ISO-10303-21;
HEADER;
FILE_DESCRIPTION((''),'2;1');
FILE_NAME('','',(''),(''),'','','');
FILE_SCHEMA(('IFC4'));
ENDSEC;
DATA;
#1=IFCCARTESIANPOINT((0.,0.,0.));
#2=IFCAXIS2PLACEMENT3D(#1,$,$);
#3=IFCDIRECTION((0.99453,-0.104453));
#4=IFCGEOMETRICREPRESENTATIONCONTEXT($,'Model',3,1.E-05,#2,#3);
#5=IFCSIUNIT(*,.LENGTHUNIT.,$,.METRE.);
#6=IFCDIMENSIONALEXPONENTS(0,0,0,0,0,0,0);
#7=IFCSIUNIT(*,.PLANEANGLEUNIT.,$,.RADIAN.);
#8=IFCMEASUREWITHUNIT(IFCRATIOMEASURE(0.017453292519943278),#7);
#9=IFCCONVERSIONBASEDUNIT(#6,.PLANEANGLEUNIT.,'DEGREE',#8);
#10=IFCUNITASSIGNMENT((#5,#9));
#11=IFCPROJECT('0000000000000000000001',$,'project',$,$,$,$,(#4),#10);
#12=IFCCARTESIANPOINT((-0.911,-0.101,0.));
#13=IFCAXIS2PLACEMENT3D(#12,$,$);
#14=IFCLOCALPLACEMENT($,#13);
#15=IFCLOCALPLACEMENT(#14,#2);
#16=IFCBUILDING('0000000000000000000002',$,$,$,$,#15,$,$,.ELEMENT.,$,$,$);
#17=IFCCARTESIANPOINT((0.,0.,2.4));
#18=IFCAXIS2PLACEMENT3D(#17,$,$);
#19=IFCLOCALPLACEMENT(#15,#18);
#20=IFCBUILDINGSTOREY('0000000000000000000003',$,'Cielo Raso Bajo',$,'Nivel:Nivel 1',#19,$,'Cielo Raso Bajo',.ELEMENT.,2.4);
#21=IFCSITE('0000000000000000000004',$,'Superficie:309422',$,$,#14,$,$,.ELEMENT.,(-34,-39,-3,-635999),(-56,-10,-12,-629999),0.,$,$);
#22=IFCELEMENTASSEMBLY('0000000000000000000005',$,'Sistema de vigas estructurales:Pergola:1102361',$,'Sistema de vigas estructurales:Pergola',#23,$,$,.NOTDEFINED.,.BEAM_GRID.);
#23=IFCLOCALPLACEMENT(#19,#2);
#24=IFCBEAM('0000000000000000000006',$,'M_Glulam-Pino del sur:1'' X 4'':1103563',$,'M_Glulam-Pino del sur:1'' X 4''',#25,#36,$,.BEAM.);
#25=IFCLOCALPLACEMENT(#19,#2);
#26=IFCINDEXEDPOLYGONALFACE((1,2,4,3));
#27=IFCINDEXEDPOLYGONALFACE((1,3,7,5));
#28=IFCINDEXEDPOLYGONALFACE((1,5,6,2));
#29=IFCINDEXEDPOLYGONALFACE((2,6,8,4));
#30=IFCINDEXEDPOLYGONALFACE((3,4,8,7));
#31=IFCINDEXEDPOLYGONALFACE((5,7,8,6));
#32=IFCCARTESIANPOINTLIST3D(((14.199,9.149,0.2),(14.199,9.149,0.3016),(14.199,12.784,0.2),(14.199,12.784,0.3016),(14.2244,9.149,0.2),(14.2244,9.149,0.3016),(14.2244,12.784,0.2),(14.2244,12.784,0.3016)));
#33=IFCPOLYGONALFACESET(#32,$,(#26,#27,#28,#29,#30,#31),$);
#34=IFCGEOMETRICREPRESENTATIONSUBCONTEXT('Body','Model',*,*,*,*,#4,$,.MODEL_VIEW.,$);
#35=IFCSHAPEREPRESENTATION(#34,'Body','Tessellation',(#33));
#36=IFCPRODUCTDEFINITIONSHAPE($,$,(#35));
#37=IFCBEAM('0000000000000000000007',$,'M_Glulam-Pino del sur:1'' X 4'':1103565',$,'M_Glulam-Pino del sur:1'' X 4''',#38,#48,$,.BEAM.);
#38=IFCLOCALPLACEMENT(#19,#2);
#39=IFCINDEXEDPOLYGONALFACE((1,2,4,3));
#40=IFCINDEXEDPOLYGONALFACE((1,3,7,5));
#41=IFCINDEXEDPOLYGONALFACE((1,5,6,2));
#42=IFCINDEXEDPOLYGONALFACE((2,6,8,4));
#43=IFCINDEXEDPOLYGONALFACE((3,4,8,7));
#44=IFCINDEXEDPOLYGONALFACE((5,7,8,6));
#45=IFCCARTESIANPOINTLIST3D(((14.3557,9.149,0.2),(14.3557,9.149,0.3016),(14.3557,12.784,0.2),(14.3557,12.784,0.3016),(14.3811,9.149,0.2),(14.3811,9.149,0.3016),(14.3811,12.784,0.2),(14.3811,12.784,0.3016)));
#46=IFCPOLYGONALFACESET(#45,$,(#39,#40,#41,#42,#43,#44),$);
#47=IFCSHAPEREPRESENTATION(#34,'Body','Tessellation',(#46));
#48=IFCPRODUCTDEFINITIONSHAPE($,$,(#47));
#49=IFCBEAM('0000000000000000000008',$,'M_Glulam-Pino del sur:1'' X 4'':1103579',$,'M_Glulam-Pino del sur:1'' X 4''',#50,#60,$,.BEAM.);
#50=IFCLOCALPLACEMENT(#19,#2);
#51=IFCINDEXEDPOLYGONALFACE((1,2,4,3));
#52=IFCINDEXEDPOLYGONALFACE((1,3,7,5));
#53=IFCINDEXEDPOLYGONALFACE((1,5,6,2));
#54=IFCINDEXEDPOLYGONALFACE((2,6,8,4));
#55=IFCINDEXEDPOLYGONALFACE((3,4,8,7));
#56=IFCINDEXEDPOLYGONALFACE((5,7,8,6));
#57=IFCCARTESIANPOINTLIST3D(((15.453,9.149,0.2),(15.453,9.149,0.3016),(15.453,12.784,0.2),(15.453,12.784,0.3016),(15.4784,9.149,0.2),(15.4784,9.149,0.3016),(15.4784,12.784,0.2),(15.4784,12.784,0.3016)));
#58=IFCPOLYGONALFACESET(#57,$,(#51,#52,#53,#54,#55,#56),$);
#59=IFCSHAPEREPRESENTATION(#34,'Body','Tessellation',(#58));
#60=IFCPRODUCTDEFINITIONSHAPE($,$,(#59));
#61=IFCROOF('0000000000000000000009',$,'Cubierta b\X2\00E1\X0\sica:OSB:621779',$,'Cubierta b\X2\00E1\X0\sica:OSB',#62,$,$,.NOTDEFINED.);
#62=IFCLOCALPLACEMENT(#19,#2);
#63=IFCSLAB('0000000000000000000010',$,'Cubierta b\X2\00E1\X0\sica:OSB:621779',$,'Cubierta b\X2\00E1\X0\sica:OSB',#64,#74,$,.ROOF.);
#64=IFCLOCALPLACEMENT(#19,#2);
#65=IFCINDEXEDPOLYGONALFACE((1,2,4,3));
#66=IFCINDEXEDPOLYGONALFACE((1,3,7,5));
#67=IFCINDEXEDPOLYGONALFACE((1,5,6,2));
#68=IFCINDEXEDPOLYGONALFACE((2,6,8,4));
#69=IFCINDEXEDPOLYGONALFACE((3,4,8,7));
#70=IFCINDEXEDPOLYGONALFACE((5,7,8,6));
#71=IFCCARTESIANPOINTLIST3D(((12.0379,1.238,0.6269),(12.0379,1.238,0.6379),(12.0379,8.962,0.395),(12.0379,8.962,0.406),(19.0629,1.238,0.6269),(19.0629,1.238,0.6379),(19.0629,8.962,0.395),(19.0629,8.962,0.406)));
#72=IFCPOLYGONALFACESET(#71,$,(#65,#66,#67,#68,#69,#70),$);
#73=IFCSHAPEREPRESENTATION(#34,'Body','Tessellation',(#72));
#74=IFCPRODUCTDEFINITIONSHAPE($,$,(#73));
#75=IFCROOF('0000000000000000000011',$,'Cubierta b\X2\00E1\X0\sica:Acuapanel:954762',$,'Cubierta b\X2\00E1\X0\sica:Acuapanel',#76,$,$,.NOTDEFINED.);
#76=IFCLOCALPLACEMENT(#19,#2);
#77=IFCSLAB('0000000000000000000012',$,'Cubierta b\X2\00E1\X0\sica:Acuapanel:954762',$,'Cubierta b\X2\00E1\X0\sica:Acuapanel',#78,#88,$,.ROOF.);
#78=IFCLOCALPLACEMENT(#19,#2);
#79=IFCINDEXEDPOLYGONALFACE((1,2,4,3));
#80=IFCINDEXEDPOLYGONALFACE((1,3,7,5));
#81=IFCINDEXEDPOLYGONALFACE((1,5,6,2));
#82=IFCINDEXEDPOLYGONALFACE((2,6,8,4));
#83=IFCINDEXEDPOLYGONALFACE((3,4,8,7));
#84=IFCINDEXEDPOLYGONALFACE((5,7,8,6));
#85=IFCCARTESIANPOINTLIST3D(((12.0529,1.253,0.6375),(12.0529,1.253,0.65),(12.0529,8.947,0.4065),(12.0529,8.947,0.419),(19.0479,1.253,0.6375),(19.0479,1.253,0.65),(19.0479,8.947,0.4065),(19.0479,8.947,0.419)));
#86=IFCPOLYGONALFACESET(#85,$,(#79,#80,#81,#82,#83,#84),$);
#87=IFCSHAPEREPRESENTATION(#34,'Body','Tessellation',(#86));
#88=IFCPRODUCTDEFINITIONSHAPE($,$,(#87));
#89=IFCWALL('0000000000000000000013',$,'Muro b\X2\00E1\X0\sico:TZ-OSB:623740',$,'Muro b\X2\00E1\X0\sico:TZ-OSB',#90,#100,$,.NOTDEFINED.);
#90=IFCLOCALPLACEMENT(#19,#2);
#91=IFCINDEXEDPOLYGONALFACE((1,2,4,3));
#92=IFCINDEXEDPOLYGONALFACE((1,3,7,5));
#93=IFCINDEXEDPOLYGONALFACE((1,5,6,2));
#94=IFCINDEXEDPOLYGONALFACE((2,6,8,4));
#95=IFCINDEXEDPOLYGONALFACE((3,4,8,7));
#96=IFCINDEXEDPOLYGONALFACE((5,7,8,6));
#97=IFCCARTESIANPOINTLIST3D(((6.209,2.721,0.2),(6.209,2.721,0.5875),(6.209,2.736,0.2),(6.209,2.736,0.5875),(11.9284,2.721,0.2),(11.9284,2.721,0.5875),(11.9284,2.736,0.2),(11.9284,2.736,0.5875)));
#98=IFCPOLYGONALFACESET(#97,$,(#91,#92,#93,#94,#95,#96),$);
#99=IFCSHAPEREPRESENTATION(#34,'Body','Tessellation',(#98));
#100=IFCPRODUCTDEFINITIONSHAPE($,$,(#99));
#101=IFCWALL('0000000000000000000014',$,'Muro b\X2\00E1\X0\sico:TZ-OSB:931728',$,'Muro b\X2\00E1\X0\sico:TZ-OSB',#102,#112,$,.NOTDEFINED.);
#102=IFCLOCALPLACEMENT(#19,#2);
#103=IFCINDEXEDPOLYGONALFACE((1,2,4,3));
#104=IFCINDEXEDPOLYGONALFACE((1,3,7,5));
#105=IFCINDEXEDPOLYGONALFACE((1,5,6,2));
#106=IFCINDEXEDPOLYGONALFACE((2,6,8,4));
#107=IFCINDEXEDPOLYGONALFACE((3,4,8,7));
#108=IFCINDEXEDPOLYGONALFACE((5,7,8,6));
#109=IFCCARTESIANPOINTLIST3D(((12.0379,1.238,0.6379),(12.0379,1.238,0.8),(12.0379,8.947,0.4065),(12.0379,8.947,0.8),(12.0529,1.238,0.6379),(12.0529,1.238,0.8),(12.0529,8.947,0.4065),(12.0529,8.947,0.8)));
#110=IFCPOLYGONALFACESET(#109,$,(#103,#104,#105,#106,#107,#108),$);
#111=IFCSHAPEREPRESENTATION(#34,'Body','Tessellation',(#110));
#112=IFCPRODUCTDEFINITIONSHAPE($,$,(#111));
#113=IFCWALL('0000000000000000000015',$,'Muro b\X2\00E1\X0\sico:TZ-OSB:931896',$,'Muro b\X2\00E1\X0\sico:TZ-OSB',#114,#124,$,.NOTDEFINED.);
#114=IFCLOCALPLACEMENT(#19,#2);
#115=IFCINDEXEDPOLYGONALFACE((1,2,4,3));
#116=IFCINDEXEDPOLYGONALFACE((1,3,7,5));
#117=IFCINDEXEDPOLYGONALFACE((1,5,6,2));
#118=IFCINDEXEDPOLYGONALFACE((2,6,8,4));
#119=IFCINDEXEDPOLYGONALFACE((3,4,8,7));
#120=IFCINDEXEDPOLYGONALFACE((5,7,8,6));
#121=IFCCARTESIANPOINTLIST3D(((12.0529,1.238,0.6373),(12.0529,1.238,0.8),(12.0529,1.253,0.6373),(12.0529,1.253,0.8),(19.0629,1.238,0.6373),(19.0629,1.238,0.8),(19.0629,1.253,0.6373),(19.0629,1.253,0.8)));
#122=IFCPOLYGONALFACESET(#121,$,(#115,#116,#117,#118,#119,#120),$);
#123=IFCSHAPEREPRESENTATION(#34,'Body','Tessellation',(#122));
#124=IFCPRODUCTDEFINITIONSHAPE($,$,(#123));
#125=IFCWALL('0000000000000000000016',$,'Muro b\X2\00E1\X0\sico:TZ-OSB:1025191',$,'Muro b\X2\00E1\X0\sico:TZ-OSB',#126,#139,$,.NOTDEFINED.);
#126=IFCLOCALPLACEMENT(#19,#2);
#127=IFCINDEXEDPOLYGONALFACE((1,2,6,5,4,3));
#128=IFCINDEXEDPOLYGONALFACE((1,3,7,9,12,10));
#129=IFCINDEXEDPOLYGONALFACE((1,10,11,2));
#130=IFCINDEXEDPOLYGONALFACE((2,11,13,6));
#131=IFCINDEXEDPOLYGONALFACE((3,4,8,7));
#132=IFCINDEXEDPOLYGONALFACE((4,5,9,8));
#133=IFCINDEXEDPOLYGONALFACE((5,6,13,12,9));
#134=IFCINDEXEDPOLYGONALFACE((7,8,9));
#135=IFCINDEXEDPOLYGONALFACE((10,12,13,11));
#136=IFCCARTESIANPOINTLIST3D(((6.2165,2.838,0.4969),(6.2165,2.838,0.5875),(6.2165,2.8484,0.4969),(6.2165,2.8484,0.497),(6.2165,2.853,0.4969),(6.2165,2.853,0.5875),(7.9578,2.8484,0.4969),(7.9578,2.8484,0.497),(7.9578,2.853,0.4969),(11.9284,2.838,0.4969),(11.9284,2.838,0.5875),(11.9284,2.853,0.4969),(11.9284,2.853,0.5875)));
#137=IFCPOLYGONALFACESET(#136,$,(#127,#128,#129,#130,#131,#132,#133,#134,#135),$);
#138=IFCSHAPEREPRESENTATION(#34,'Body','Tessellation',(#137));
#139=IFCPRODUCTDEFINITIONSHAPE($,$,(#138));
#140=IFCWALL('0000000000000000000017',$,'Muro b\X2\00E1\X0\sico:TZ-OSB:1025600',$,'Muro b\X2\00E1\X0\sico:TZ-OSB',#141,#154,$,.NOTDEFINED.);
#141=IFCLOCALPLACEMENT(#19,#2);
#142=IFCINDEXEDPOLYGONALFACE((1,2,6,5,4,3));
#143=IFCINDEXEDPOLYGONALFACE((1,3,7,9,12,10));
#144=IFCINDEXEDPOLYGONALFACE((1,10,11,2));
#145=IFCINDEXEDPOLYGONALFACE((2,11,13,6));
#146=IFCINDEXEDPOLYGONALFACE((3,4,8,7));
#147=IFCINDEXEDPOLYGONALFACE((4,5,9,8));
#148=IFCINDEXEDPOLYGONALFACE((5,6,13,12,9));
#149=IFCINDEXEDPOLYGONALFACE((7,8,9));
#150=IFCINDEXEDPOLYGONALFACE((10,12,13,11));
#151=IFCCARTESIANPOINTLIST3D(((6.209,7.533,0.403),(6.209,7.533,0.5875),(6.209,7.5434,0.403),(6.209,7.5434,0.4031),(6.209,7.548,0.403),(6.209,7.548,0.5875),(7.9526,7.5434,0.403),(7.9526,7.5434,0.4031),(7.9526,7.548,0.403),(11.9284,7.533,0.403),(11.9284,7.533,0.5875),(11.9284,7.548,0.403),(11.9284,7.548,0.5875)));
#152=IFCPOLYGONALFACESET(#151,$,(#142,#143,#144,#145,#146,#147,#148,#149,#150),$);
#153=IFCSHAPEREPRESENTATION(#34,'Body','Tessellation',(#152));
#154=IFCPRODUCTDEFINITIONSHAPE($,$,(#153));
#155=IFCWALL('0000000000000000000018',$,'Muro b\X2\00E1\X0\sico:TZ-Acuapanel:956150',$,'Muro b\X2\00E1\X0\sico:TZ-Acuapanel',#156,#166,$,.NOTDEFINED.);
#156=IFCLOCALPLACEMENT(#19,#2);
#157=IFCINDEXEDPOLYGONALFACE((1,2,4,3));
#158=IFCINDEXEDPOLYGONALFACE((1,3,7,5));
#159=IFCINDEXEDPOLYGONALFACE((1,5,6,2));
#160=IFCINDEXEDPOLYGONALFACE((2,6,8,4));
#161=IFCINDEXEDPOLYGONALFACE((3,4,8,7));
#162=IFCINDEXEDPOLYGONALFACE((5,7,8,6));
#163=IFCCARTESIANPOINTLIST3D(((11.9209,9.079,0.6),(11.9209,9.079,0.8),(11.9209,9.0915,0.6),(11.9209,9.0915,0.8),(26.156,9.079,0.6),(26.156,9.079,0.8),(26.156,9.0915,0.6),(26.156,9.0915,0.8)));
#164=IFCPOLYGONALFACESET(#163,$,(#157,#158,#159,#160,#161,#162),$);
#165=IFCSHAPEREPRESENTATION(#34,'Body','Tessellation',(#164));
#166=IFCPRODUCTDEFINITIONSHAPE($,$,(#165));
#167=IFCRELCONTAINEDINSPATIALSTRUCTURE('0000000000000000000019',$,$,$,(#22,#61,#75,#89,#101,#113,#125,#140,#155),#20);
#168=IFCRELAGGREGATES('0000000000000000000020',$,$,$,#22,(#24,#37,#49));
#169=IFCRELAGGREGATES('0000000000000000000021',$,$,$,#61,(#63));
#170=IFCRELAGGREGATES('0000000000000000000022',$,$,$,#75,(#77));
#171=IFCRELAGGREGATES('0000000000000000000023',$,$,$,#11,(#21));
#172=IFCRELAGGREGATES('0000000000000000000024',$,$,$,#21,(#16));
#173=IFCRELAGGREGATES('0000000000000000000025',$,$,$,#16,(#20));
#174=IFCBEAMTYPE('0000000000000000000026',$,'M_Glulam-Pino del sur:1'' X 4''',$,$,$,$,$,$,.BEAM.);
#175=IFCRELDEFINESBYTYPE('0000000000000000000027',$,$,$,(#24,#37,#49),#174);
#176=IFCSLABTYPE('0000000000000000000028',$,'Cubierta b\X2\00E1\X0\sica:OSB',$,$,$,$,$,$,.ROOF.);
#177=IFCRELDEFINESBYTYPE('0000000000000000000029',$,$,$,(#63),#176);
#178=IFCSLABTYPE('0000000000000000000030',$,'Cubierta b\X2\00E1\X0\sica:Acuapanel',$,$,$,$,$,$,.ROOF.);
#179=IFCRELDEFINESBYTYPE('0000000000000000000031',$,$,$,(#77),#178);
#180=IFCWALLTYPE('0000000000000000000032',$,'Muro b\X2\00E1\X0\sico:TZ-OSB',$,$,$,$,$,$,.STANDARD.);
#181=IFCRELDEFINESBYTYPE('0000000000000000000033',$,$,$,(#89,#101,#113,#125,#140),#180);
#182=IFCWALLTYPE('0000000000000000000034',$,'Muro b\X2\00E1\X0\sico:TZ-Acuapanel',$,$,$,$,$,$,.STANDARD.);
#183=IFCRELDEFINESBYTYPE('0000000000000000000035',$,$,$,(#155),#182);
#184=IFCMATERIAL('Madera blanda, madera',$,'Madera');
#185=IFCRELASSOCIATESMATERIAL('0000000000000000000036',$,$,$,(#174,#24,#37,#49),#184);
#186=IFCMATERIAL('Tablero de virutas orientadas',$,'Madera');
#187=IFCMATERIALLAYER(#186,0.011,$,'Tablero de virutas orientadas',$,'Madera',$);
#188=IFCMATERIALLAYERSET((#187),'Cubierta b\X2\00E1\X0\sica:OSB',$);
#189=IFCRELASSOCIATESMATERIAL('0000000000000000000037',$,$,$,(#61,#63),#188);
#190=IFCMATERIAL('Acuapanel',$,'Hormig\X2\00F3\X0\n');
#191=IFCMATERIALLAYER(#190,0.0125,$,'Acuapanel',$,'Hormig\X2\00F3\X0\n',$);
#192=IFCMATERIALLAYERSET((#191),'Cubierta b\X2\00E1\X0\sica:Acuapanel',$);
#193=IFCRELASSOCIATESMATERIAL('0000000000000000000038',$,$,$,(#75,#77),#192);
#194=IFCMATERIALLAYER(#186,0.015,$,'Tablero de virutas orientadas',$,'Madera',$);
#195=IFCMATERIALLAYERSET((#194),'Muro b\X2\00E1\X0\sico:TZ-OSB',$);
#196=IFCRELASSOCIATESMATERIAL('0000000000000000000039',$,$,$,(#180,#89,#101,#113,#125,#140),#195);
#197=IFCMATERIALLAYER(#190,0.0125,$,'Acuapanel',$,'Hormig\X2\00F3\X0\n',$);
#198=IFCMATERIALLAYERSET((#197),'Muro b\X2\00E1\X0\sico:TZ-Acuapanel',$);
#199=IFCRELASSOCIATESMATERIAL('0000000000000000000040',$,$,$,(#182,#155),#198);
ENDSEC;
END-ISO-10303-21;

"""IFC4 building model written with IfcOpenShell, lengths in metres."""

from ifc_helpers import new_model, entity, si_unit, converted_unit, direction, frame, frame_2d, origin, origin_2d_with_axis, place, context, subcontext, project, spatial, polyline, segment, composite_curve, rectangle, outline, extrude, clip, halfspace, bounded_halfspace, source, transform, mapped, material, layer, layer_set, layer_usage, material_profile, profile_set, profile_usage, type_object, type_shapes, element, aggregate, save


model = new_model("IFC4")

# Units and contexts
model_context = context("Model", 3, precision=1e-05, world=origin(), true_north=direction((0.99453, -0.104453)))
body_context = subcontext(model_context, "Body", "Model", "MODEL_VIEW")
ifc_project = project(units=[si_unit("LENGTHUNIT", "METRE"), converted_unit("PLANEANGLEUNIT", "DEGREE", entity("IfcRatioMeasure", 0.017453292519943278), si_unit("PLANEANGLEUNIT", "RADIAN"), dimensions=[0, 0, 0, 0, 0, 0, 0])], contexts=[model_context])

# Site, building, storey
site_placement = place(None, frame((-0.911, -0.101, 0.0)))
site = spatial("IfcSite", under=ifc_project, at=site_placement, Name="Superficie:309422", CompositionType="ELEMENT", RefLatitude=(-34, -39, -3, -635999), RefLongitude=(-56, -10, -12, -629999), RefElevation=0.0)
building_placement = place(site_placement, origin())
building = spatial("IfcBuilding", under=site, at=building_placement, CompositionType="ELEMENT")
storey_placement = place(building_placement, frame((0.0, 0.0, 2.4)))
storey = spatial("IfcBuildingStorey", under=building, at=storey_placement, Name="Cielo Raso Bajo", ObjectType="Nivel:Nivel 1", LongName="Cielo Raso Bajo", CompositionType="ELEMENT", Elevation=2.4)

# Element assembly, beams
assembly_placement = place(storey_placement, origin())
assembly = element("IfcElementAssembly", 1, at=assembly_placement, inside=storey, Name="Sistema de vigas estructurales:Pergola:1102361", ObjectType="Sistema de vigas estructurales:Pergola", AssemblyPlace="NOTDEFINED", PredefinedType="BEAM_GRID")
ifc_material_1 = material(Name="Madera blanda, madera", Category="Madera")
ifc_material_profile_1 = material_profile(ifc_material_1, outline(composite_curve([segment(polyline([(-0.0127, 0.0508, 0.0), (0.0127, 0.0508, 0.0)]), True, "CONTINUOUS"), segment(polyline([(0.0127, 0.0508, 0.0), (0.0127, -0.0508, 0.0)]), True, "CONTINUOUS"), segment(polyline([(0.0127, -0.0508, 0.0), (-0.0127, -0.0508, 0.0)]), True, "CONTINUOUS"), segment(polyline([(-0.0127, -0.0508, 0.0), (-0.0127, 0.0508, 0.0)]), True, "CONTINUOUS")], self_intersect=False), kind="CURVE"), Name="1' X 4'")
ifc_material_profile_2 = material_profile(ifc_material_1, outline(composite_curve([segment(polyline([(2.5145, -0.0127, -0.0508), (2.5145, -0.0127, 0.0508)]), True, "CONTINUOUS"), segment(polyline([(2.5145, -0.0127, 0.0508), (-2.5145, -0.0127, 0.0508)]), True, "CONTINUOUS"), segment(polyline([(-2.5145, -0.0127, 0.0508), (-2.5145, -0.0127, -0.0508)]), True, "CONTINUOUS"), segment(polyline([(-2.5145, -0.0127, -0.0508), (2.5145, -0.0127, -0.0508)]), True, "CONTINUOUS")], self_intersect=False), kind="CURVE"), Name="1' X 4'")
ifc_profile_set = profile_set([ifc_material_profile_1, ifc_material_profile_2], Name="1' X 4'")
ifc_profile_usage_1 = profile_usage(ifc_profile_set, cardinal=8)
beam_type = type_object("IfcBeamType", Name="M_Glulam-Pino del sur:1' X 4'", PredefinedType="BEAM", material=ifc_profile_set)
shared_shape = source(origin(), body_context, "Body", "SweptSolid", [
    extrude(rectangle(XDim=0.1016, YDim=0.0254, at=origin_2d_with_axis()), frame((-1.7485, 0.0, 0.0), z_axis=(1.0, 0.0, 0.0), x_axis=(0.0, 0.0, -1.0)), (0.0, 0.0, 1.0), 3.635),
])
type_shapes(beam_type, [shared_shape])
beam_1_placement = place(assembly_placement, frame((14.2117, 10.8975, 0.2508), z_axis=(0.0, 0.0, 1.0), x_axis=(0.0, 1.0, 0.0)))
beam_1 = element("IfcBeam", 2, at=beam_1_placement, type_object=beam_type, material=ifc_profile_usage_1, Name="M_Glulam-Pino del sur:1' X 4':1103563", ObjectType="M_Glulam-Pino del sur:1' X 4'", PredefinedType="BEAM", context=body_context, shape_type="MappedRepresentation", body=[
    mapped(shared_shape, transform((0.0, 0.0, 0.0), scale=1.0)),
])
ifc_profile_usage_2 = profile_usage(ifc_profile_set, cardinal=8)
beam_2_placement = place(assembly_placement, frame((14.3684, 10.8975, 0.2508), z_axis=(0.0, 0.0, 1.0), x_axis=(0.0, 1.0, 0.0)))
beam_2 = element("IfcBeam", 3, at=beam_2_placement, type_object=beam_type, material=ifc_profile_usage_2, Name="M_Glulam-Pino del sur:1' X 4':1103565", ObjectType="M_Glulam-Pino del sur:1' X 4'", PredefinedType="BEAM", context=body_context, shape_type="MappedRepresentation", body=[
    mapped(shared_shape, transform((0.0, 0.0, 0.0), scale=1.0)),
])
ifc_profile_usage_3 = profile_usage(ifc_profile_set, cardinal=8)
beam_3_placement = place(assembly_placement, frame((15.4657, 10.8975, 0.2508), z_axis=(0.0, 0.0, 1.0), x_axis=(0.0, 1.0, 0.0)))
beam_3 = element("IfcBeam", 4, at=beam_3_placement, type_object=beam_type, material=ifc_profile_usage_3, Name="M_Glulam-Pino del sur:1' X 4':1103579", ObjectType="M_Glulam-Pino del sur:1' X 4'", PredefinedType="BEAM", context=body_context, shape_type="MappedRepresentation", body=[
    mapped(shared_shape, transform((0.0, 0.0, 0.0), scale=1.0)),
])
aggregate(assembly, [beam_1, beam_2, beam_3])

# Roofs, slabs
ifc_material_2 = material(Name="Tablero de virutas orientadas", Category="Madera")
ifc_layer_1 = layer(ifc_material_2, 0.011, Name="Tablero de virutas orientadas", Category="Madera")
ifc_layer_set_1 = layer_set([ifc_layer_1], Name="Cubierta básica:OSB")
roof_1_placement = place(storey_placement, frame((12.0379, 1.238, 0.395)))
roof_1 = element("IfcRoof", 5, at=roof_1_placement, inside=storey, material=ifc_layer_set_1, Name="Cubierta básica:OSB:621779", ObjectType="Cubierta básica:OSB", PredefinedType="NOTDEFINED")
slab_type_1 = type_object("IfcSlabType", Name="Cubierta básica:OSB", PredefinedType="ROOF")
slab_1_placement = place(roof_1_placement, origin())
slab_1 = element("IfcSlab", 6, at=slab_1_placement, type_object=slab_type_1, material=ifc_layer_set_1, Name="Cubierta básica:OSB:621779", ObjectType="Cubierta básica:OSB", PredefinedType="ROOF", context=body_context, shape_type="SweptSolid", body=[
    extrude(rectangle(XDim=7.025, YDim=7.7275, at=frame_2d((0.0, 0.0), x_axis=(1.0, 0.0))), frame((3.5125, 3.862, 0.116), z_axis=(0.0, 0.030015, 0.999549), x_axis=(1.0, 0.0, 0.0)), (0.0, -0.030015, 0.999549), 0.011),
])
aggregate(roof_1, [slab_1])
ifc_material_3 = material(Name="Acuapanel", Category="Hormigón")
ifc_layer_2 = layer(ifc_material_3, 0.0125, Name="Acuapanel", Category="Hormigón")
ifc_layer_set_2 = layer_set([ifc_layer_2], Name="Cubierta básica:Acuapanel")
roof_2_placement = place(storey_placement, frame((12.0529, 1.253, 0.4065)))
roof_2 = element("IfcRoof", 7, at=roof_2_placement, inside=storey, material=ifc_layer_set_2, Name="Cubierta básica:Acuapanel:954762", ObjectType="Cubierta básica:Acuapanel", PredefinedType="NOTDEFINED")
slab_type_2 = type_object("IfcSlabType", Name="Cubierta básica:Acuapanel", PredefinedType="ROOF")
slab_2_placement = place(roof_2_placement, origin())
slab_2 = element("IfcSlab", 8, at=slab_2_placement, type_object=slab_type_2, material=ifc_layer_set_2, Name="Cubierta básica:Acuapanel:954762", ObjectType="Cubierta básica:Acuapanel", PredefinedType="ROOF", context=body_context, shape_type="SweptSolid", body=[
    extrude(rectangle(XDim=6.995, YDim=7.6975, at=frame_2d((0.0, 0.0), x_axis=(1.0, 0.0))), frame((3.4975, 3.847, 0.1155), z_axis=(0.0, 0.030015, 0.999549), x_axis=(1.0, 0.0, 0.0)), (0.0, -0.030015, 0.999549), 0.0125),
])
aggregate(roof_2, [slab_2])

# Walls
ifc_layer_3 = layer(ifc_material_2, 0.015, Name="Tablero de virutas orientadas", Category="Madera")
ifc_layer_set_3 = layer_set([ifc_layer_3], Name="Muro básico:TZ-OSB")
ifc_layer_usage_1 = layer_usage(ifc_layer_set_3, "AXIS2", "NEGATIVE", 0.0075)
wall_type_1 = type_object("IfcWallType", Name="Muro básico:TZ-OSB", PredefinedType="STANDARD", material=ifc_layer_set_3)
wall_1_placement = place(storey_placement, frame((11.9284, 2.7285, 0.2), z_axis=(0.0, 0.0, 1.0), x_axis=(-1.0, 0.0, 0.0)))
element("IfcWall", 9, at=wall_1_placement, inside=storey, type_object=wall_type_1, material=ifc_layer_usage_1, Name="Muro básico:TZ-OSB:623740", ObjectType="Muro básico:TZ-OSB", PredefinedType="NOTDEFINED", context=body_context, shape_type="SweptSolid", body=[
    extrude(rectangle(XDim=5.7194, YDim=0.015, at=frame_2d((2.8597, 0.0), x_axis=(-1.0, 0.0))), origin(), (0.0, 0.0, 1.0), 0.3875),
])
ifc_layer_usage_2 = layer_usage(ifc_layer_set_3, "AXIS2", "NEGATIVE", 0.0075)
wall_2_placement = place(storey_placement, frame((12.0454, 8.947, 0.4065), z_axis=(0.0, 0.0, 1.0), x_axis=(0.0, -1.0, 0.0)))
element("IfcWall", 10, at=wall_2_placement, inside=storey, type_object=wall_type_1, material=ifc_layer_usage_2, Name="Muro básico:TZ-OSB:931728", ObjectType="Muro básico:TZ-OSB", PredefinedType="NOTDEFINED", context=body_context, shape_type="Clipping", body=[
    clip(extrude(rectangle(XDim=7.709, YDim=0.015, at=frame_2d((3.8545, 0.0), x_axis=(-1.0, 0.0))), origin(), (0.0, 0.0, 1.0), 0.3935), halfspace(frame((7.709, -0.0075, 0.2315), z_axis=(0.030015, 0.0, -0.999549), x_axis=(0.0, 1.0, 0.0)), False)),
])
ifc_layer_usage_3 = layer_usage(ifc_layer_set_3, "AXIS2", "NEGATIVE", 0.0075)
wall_3_placement = place(storey_placement, frame((12.0529, 1.2455, 0.6373)))
element("IfcWall", 11, at=wall_3_placement, inside=storey, type_object=wall_type_1, material=ifc_layer_usage_3, Name="Muro básico:TZ-OSB:931896", ObjectType="Muro básico:TZ-OSB", PredefinedType="NOTDEFINED", context=body_context, shape_type="SweptSolid", body=[
    extrude(rectangle(XDim=7.01, YDim=0.015, at=frame_2d((3.505, 0.0), x_axis=(-1.0, 0.0))), origin(), (0.0, 0.0, 1.0), 0.1627),
])
ifc_layer_usage_4 = layer_usage(ifc_layer_set_3, "AXIS2", "POSITIVE", -0.0075)
wall_4_placement = place(storey_placement, frame((11.9284, 2.8455, 0.4969), z_axis=(0.0, 0.0, 1.0), x_axis=(-1.0, 0.0, 0.0)))
element("IfcWall", 12, at=wall_4_placement, inside=storey, type_object=wall_type_1, material=ifc_layer_usage_4, Name="Muro básico:TZ-OSB:1025191", ObjectType="Muro básico:TZ-OSB", PredefinedType="NOTDEFINED", context=body_context, shape_type="Clipping", body=[
    clip(extrude(rectangle(XDim=5.7119, YDim=0.015, at=frame_2d((2.856, 0.0), x_axis=(-1.0, 0.0))), origin(), (0.0, 0.0, 1.0), 0.0906), bounded_halfspace(frame((5.7119, -0.0075, 0.0), z_axis=(0.0, -0.019983, 0.9998), x_axis=(1.0, 0.0, 0.0)), True, frame((5.7119, -0.0075, 0.0), z_axis=(0.0, -0.019983, 0.9998), x_axis=(1.0, 0.0, 0.0)), polyline([(0.0, 0.0), (0.0, 0.0046), (-1.7413, 0.0046), (-1.7413, 0.0), (-1.7352, 0.0), (-0.0061, 0.0), (0.0, 0.0)]))),
])
ifc_layer_usage_5 = layer_usage(ifc_layer_set_3, "AXIS2", "NEGATIVE", 0.0075)
wall_5_placement = place(storey_placement, frame((11.9284, 7.5405, 0.403), z_axis=(0.0, 0.0, 1.0), x_axis=(-1.0, 0.0, 0.0)))
element("IfcWall", 13, at=wall_5_placement, inside=storey, type_object=wall_type_1, material=ifc_layer_usage_5, Name="Muro básico:TZ-OSB:1025600", ObjectType="Muro básico:TZ-OSB", PredefinedType="NOTDEFINED", context=body_context, shape_type="Clipping", body=[
    clip(extrude(rectangle(XDim=5.7194, YDim=0.015, at=frame_2d((2.8597, 0.0), x_axis=(-1.0, 0.0))), origin(), (0.0, 0.0, 1.0), 0.1845), bounded_halfspace(frame((5.7194, -0.0075, 0.0), z_axis=(0.0, -0.019983, 0.9998), x_axis=(1.0, 0.0, 0.0)), True, frame((5.7194, -0.0075, 0.0), z_axis=(0.0, -0.019983, 0.9998), x_axis=(1.0, 0.0, 0.0)), polyline([(0.0, 0.0), (0.0, 0.0046), (-0.0046, 0.0046), (-0.0084, 0.0046), (-1.7375, 0.0046), (-1.7436, 0.0046), (-1.7436, 0.0), (0.0, 0.0)]))),
])
ifc_layer_4 = layer(ifc_material_3, 0.0125, Name="Acuapanel", Category="Hormigón")
ifc_layer_set_4 = layer_set([ifc_layer_4], Name="Muro básico:TZ-Acuapanel")
wall_type_2 = type_object("IfcWallType", Name="Muro básico:TZ-Acuapanel", PredefinedType="STANDARD", material=ifc_layer_set_4)
ifc_layer_usage_6 = layer_usage(ifc_layer_set_4, "AXIS2", "NEGATIVE", 0.0063)
wall_6_placement = place(storey_placement, frame((11.9209, 9.0853, 0.6)))
element("IfcWall", 14, at=wall_6_placement, inside=storey, type_object=wall_type_2, material=ifc_layer_usage_6, Name="Muro básico:TZ-Acuapanel:956150", ObjectType="Muro básico:TZ-Acuapanel", PredefinedType="NOTDEFINED", context=body_context, shape_type="Clipping", body=[
    clip(extrude(rectangle(XDim=14.235, YDim=0.0125, at=frame_2d((7.1175, 0.0), x_axis=(-1.0, 0.0))), origin(), (0.0, 0.0, 1.0), 0.2), bounded_halfspace(frame((0.0, -0.0063, 0.2)), False, frame((0.0, -0.0063, 0.2)), polyline([(0.0, 0.0), (4.3388, 0.0), (4.3388, 0.0038), (0.0, 0.0038), (0.0, 0.0)]))),
])

save(model, "model.ifc")
